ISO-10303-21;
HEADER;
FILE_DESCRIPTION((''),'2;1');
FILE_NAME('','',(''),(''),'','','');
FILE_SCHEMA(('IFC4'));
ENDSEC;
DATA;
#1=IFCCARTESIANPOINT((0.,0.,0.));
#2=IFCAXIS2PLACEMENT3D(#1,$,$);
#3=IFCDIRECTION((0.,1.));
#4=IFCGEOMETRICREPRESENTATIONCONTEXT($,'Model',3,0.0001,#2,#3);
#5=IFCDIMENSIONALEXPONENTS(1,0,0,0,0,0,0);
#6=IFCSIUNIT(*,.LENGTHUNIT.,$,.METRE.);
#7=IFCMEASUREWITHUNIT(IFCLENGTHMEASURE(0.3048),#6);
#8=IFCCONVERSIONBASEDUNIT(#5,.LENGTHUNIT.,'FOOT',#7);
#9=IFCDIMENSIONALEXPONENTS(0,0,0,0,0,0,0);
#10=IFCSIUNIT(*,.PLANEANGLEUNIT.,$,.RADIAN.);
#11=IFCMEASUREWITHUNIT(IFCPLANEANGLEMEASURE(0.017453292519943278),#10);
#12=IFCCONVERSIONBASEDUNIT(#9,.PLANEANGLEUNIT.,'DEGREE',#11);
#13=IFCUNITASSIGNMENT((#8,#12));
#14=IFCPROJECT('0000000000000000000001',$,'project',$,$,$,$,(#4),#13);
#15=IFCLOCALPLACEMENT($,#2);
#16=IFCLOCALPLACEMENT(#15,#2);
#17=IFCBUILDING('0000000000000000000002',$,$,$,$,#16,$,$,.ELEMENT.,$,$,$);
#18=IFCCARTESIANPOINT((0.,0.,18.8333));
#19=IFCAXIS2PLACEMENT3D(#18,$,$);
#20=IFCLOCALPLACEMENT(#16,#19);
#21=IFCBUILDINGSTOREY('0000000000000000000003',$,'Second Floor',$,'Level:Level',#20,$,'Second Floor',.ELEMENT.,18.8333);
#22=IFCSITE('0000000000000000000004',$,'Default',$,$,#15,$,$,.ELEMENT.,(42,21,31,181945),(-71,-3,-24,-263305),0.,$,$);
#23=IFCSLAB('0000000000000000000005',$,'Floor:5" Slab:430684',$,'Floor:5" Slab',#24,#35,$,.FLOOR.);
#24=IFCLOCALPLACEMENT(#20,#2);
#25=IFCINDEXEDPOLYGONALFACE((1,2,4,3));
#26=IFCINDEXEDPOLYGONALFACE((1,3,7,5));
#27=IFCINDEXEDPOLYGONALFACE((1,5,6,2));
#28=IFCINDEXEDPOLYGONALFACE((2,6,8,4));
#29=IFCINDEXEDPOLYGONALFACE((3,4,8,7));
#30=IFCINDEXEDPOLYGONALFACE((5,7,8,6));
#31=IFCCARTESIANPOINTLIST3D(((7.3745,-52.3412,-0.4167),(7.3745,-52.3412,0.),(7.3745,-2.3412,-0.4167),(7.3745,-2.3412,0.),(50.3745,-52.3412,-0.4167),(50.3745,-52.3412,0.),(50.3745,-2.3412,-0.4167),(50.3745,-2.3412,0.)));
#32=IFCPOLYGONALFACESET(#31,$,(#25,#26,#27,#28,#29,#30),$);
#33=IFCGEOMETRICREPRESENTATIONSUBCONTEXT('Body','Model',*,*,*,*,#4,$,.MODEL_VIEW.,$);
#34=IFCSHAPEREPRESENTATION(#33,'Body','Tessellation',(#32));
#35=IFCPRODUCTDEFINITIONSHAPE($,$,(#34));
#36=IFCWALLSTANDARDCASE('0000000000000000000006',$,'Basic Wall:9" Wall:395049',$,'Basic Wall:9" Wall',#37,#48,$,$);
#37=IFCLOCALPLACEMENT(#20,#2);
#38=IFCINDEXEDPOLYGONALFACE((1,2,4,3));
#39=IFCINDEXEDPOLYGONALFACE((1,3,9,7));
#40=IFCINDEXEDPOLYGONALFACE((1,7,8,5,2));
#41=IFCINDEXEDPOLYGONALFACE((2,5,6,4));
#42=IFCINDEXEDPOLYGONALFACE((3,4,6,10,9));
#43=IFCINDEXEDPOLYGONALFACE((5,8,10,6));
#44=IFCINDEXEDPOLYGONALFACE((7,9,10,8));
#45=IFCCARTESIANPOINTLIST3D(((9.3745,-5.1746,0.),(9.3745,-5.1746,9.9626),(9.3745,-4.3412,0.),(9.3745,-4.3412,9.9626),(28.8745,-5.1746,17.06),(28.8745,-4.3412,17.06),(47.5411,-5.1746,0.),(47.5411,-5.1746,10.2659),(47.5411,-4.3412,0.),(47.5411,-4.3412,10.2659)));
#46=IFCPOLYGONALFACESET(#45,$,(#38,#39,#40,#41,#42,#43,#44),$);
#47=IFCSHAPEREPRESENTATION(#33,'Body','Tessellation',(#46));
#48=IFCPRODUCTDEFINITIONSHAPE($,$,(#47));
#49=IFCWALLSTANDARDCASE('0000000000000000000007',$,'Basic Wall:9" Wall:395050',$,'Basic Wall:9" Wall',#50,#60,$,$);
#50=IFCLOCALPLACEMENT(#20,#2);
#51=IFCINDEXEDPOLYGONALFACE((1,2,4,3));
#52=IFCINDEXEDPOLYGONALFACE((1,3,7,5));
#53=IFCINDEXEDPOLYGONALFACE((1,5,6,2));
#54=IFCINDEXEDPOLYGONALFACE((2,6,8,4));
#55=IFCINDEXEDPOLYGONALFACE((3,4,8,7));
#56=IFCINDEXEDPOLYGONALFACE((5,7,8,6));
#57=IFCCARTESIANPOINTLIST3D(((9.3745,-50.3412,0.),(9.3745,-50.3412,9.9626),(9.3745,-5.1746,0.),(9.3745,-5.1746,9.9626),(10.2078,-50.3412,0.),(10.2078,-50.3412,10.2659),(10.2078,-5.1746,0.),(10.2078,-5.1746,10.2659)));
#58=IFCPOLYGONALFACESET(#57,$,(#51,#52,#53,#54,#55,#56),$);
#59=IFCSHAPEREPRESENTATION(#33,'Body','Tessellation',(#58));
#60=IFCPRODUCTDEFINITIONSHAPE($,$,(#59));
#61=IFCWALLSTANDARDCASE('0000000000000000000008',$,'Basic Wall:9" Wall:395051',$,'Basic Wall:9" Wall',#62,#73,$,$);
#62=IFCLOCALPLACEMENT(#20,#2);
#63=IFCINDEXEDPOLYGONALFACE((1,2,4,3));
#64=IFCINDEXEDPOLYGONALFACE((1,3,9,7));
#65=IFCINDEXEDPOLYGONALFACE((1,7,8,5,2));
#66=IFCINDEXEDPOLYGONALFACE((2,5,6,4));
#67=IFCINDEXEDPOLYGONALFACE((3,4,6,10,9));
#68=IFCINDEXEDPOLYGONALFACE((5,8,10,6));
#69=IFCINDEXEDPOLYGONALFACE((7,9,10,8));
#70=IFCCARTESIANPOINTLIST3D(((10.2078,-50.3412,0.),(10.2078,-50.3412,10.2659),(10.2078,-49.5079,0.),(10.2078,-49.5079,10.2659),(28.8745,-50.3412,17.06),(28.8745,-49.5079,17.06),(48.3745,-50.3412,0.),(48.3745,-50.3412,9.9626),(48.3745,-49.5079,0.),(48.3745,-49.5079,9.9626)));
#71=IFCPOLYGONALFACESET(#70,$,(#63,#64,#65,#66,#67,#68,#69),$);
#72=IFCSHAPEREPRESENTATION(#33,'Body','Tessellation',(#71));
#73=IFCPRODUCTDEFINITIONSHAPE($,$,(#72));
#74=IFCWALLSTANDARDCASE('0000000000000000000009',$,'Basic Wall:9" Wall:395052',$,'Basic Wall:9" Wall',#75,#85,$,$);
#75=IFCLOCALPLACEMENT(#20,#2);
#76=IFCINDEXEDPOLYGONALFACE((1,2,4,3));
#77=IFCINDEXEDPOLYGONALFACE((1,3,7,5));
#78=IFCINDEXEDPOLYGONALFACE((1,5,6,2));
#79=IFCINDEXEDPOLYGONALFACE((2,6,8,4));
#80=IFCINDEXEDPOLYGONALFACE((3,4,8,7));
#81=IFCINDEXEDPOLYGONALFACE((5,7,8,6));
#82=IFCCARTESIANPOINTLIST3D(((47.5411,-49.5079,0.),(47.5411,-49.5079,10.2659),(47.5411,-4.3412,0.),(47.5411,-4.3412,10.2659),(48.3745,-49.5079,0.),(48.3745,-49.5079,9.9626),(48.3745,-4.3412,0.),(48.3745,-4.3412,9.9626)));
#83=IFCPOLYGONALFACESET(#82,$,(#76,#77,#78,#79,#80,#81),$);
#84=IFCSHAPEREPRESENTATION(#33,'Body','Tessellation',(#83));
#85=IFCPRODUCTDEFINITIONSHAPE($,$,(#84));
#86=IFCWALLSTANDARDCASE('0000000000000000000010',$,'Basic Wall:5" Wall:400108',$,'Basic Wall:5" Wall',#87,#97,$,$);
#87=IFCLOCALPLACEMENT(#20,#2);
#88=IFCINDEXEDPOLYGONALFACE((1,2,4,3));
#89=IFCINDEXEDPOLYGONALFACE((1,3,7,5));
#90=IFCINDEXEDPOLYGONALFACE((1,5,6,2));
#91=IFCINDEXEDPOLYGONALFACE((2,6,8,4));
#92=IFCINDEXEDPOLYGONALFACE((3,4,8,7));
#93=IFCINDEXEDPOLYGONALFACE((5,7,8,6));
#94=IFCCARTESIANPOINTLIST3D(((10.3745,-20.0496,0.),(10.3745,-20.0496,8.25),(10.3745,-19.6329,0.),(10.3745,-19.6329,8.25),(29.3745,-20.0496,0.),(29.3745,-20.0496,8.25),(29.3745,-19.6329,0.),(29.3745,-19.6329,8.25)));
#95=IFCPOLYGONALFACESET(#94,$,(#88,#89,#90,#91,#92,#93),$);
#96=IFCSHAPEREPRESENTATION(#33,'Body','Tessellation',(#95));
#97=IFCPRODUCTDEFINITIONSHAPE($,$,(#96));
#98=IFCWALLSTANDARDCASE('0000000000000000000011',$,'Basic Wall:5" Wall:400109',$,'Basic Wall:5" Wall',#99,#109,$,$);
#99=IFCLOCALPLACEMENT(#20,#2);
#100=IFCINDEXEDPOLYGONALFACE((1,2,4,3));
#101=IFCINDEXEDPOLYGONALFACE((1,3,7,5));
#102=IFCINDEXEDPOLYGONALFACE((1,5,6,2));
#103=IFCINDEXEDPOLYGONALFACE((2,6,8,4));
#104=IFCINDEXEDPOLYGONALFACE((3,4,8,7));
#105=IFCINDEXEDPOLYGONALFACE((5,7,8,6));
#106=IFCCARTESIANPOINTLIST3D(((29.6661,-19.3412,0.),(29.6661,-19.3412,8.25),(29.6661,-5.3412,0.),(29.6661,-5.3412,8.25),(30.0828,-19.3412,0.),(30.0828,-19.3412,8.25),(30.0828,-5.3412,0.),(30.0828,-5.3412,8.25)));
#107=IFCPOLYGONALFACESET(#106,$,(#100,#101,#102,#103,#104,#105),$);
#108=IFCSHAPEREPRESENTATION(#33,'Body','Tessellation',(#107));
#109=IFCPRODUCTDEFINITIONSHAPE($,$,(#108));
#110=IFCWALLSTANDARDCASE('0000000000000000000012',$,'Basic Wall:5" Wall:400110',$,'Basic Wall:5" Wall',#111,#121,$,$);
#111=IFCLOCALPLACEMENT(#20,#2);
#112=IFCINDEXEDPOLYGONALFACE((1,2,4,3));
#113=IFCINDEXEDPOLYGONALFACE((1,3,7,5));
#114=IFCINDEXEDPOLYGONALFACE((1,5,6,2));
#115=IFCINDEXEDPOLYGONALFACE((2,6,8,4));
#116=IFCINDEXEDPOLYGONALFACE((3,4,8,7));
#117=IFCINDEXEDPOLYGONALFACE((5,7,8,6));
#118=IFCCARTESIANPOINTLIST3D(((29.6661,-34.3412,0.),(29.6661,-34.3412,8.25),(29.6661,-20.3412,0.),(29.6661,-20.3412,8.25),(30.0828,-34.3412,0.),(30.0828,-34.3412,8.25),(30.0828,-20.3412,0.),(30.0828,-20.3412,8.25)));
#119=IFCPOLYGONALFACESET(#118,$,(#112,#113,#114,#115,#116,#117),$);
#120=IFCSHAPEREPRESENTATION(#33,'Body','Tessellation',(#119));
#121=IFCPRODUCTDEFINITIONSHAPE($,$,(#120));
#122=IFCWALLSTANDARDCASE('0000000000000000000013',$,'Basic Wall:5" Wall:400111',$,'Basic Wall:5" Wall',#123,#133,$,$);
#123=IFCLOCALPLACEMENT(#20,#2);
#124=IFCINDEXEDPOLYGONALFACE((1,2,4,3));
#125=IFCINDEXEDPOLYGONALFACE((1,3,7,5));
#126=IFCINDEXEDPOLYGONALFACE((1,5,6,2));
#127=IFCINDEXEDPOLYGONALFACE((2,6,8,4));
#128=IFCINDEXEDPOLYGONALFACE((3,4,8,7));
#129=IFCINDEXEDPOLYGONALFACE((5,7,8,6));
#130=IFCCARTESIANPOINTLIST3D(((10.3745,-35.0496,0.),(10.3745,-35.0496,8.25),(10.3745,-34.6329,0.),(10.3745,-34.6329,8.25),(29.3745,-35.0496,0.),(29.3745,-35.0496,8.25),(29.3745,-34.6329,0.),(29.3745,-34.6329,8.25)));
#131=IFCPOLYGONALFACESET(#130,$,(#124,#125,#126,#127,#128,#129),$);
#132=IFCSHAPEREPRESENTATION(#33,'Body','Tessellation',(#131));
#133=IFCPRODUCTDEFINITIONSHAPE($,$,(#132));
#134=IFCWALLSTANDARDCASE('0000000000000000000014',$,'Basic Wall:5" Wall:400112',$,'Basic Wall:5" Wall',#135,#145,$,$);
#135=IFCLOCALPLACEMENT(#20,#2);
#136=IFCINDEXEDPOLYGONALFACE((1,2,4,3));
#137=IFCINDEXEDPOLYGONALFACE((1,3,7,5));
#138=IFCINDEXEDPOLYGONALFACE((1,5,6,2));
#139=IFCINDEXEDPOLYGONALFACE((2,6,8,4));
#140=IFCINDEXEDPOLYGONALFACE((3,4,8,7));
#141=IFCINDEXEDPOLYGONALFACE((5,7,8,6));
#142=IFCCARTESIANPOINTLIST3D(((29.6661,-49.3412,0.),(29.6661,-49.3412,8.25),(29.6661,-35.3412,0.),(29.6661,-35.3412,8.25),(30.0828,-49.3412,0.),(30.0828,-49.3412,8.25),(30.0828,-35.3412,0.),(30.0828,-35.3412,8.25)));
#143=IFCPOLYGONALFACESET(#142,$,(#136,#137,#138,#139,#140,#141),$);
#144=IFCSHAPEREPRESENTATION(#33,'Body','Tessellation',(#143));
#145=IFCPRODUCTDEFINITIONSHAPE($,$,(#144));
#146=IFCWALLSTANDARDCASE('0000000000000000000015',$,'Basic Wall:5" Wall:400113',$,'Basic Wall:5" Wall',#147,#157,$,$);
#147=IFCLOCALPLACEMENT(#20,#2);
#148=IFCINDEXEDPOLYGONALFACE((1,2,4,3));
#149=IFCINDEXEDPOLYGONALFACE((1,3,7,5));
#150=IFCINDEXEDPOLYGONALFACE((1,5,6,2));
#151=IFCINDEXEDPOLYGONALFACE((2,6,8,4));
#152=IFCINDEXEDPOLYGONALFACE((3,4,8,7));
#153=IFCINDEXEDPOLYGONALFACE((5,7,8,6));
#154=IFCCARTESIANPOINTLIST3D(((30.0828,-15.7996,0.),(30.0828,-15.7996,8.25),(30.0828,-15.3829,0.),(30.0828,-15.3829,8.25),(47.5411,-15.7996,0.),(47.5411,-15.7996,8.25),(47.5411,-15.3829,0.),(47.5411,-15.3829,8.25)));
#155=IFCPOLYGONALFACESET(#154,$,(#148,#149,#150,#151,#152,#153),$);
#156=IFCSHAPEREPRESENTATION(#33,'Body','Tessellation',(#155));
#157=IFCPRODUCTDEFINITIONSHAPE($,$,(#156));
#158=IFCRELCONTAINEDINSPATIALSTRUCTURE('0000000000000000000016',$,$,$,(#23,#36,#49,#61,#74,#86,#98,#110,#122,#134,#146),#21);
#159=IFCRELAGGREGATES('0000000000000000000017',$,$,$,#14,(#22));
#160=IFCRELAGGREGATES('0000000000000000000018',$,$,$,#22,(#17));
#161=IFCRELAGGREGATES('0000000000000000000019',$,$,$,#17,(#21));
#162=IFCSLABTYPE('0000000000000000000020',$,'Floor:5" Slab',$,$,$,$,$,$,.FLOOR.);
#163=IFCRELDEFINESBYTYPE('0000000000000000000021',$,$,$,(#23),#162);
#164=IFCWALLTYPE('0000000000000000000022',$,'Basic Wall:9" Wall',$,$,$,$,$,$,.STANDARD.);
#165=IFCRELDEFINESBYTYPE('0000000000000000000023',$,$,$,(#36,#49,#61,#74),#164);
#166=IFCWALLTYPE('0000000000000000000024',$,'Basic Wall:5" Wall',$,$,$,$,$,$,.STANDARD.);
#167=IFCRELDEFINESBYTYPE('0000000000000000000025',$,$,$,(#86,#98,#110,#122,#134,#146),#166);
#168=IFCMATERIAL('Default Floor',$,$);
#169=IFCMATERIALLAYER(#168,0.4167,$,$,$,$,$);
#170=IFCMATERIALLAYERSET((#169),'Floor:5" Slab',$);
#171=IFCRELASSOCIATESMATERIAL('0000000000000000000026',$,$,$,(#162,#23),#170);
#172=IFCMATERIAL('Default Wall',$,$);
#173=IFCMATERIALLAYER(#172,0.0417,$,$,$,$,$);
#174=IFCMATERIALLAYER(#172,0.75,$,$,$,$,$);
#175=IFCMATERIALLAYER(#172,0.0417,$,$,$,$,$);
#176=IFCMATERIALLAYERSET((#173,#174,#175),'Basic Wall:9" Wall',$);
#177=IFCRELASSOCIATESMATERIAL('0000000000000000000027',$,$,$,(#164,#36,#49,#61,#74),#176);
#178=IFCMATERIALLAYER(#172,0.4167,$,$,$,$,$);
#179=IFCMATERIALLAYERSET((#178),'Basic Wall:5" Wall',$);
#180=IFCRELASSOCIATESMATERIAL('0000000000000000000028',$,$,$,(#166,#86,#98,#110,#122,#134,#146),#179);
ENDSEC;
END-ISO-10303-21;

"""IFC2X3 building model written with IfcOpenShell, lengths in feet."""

from ifc_helpers import new_model, entity, si_unit, converted_unit, direction, frame, frame_2d, origin, origin_2d_with_axis, place, context, subcontext, project, spatial, polyline, rectangle, extrude, clip, bounded_halfspace, material, layer, layer_set, layer_usage, type_object, element, save


model = new_model("IFC2X3")

# Units and contexts
model_context = context("Model", 3, precision=0.0001, world=origin(), true_north=direction((0.0, 1.0)))
body_context = subcontext(model_context, "Body", "Model", "MODEL_VIEW")
ifc_project = project(units=[converted_unit("LENGTHUNIT", "FOOT", entity("IfcLengthMeasure", 0.3048), si_unit("LENGTHUNIT", "METRE"), dimensions=[1, 0, 0, 0, 0, 0, 0]), converted_unit("PLANEANGLEUNIT", "DEGREE", entity("IfcPlaneAngleMeasure", 0.017453292519943278), si_unit("PLANEANGLEUNIT", "RADIAN"), dimensions=[0, 0, 0, 0, 0, 0, 0])], contexts=[model_context])

# Site, building, storey
site_placement = place(None, origin())
site = spatial("IfcSite", under=ifc_project, at=site_placement, Name="Default", CompositionType="ELEMENT", RefLatitude=(42, 21, 31, 181945), RefLongitude=(-71, -3, -24, -263305), RefElevation=0.0)
building_placement = place(site_placement, origin())
building = spatial("IfcBuilding", under=site, at=building_placement, CompositionType="ELEMENT")
storey_placement = place(building_placement, frame((0.0, 0.0, 18.8333)))
storey = spatial("IfcBuildingStorey", under=building, at=storey_placement, Name="Second Floor", ObjectType="Level:Level", LongName="Second Floor", CompositionType="ELEMENT", Elevation=18.8333)

# Slab
ifc_material_1 = material(Name="Default Floor")
ifc_layer_1 = layer(ifc_material_1, 0.4167)
ifc_layer_set_1 = layer_set([ifc_layer_1], Name="Floor:5\" Slab")
ifc_layer_usage_1 = layer_usage(ifc_layer_set_1, "AXIS3", "POSITIVE", 0.0)
slab_type = type_object("IfcSlabType", Name="Floor:5\" Slab", PredefinedType="FLOOR", material=ifc_layer_set_1)
slab_placement = place(storey_placement, origin())
element("IfcSlab", 1, at=slab_placement, inside=storey, type_object=slab_type, material=ifc_layer_usage_1, Name="Floor:5\" Slab:430684", ObjectType="Floor:5\" Slab", PredefinedType="FLOOR", context=body_context, shape_type="SweptSolid", body=[
    extrude(rectangle(XDim=50.0, YDim=43.0, at=origin_2d_with_axis()), frame((28.8745, -27.3412, 0.0), z_axis=(0.0, 0.0, -1.0), x_axis=(0.0, 1.0, 0.0)), (0.0, 0.0, 1.0), 0.4167),
])

# Walls
ifc_material_2 = material(Name="Default Wall")
ifc_layer_2 = layer(ifc_material_2, 0.0417)
ifc_layer_3 = layer(ifc_material_2, 0.75)
ifc_layer_4 = layer(ifc_material_2, 0.0417)
ifc_layer_set_2 = layer_set([ifc_layer_2, ifc_layer_3, ifc_layer_4], Name="Basic Wall:9\" Wall")
ifc_layer_usage_2 = layer_usage(ifc_layer_set_2, "AXIS2", "NEGATIVE", 0.4167)
wall_type_1 = type_object("IfcWallType", Name="Basic Wall:9\" Wall", PredefinedType="STANDARD", material=ifc_layer_set_2)
wall_1_placement = place(storey_placement, frame((9.3745, -4.7579, 0.0)))
element("IfcWallStandardCase", 2, at=wall_1_placement, inside=storey, type_object=wall_type_1, material=ifc_layer_usage_2, Name="Basic Wall:9\" Wall:395049", ObjectType="Basic Wall:9\" Wall", context=body_context, shape_type="Clipping", body=[
    clip(clip(extrude(rectangle(XDim=38.1667, YDim=0.8333, at=frame_2d((19.0833, 0.0), x_axis=(-1.0, 0.0))), origin(), (0.0, 0.0, 1.0), 17.06), bounded_halfspace(frame((0.0, -0.4167, 9.9626), z_axis=(-0.34202, 0.0, 0.939693), x_axis=(0.0, -1.0, 0.0)), False, frame((0.0, -0.4167, 9.9626)), polyline([(0.0, 0.0), (0.8333, 0.0), (19.5, 0.0), (19.5, 0.8333), (0.0, 0.8333), (0.0, 0.0)]))), bounded_halfspace(frame((19.5, -0.4167, 17.06), z_axis=(0.34202, 0.0, 0.939693), x_axis=(0.0, 1.0, 0.0)), False, frame((19.5, -0.4167, 17.06)), polyline([(0.0, 0.0), (18.6667, 0.0), (18.6667, 0.8333), (0.0, 0.8333), (0.0, 0.0)]))),
])
wall_2_placement = place(storey_placement, frame((9.7911, -50.3412, 0.0), z_axis=(0.0, 0.0, 1.0), x_axis=(0.0, 1.0, 0.0)))
element("IfcWallStandardCase", 3, at=wall_2_placement, inside=storey, type_object=wall_type_1, material=ifc_layer_usage_2, Name="Basic Wall:9\" Wall:395050", ObjectType="Basic Wall:9\" Wall", context=body_context, shape_type="Clipping", body=[
    clip(extrude(rectangle(XDim=45.1667, YDim=0.8333, at=frame_2d((22.5833, 0.0), x_axis=(-1.0, 0.0))), origin(), (0.0, 0.0, 1.0), 10.2659), bounded_halfspace(frame((0.0, -0.4167, 10.2659), z_axis=(0.0, 0.34202, 0.939693), x_axis=(-1.0, 0.0, 0.0)), False, frame((0.0, -0.4167, 10.2659)), polyline([(0.0, 0.0), (0.8333, 0.0), (45.1667, 0.0), (45.1667, 0.8333), (0.0, 0.8333), (0.0, 0.0)]))),
])
wall_3_placement = place(storey_placement, frame((48.3745, -49.9246, 0.0), z_axis=(0.0, 0.0, 1.0), x_axis=(-1.0, 0.0, 0.0)))
element("IfcWallStandardCase", 4, at=wall_3_placement, inside=storey, type_object=wall_type_1, material=ifc_layer_usage_2, Name="Basic Wall:9\" Wall:395051", ObjectType="Basic Wall:9\" Wall", context=body_context, shape_type="Clipping", body=[
    clip(clip(extrude(rectangle(XDim=38.1667, YDim=0.8333, at=frame_2d((19.0833, 0.0), x_axis=(-1.0, 0.0))), origin(), (0.0, 0.0, 1.0), 17.06), bounded_halfspace(frame((19.5, -0.4167, 17.06), z_axis=(0.34202, 0.0, 0.939693), x_axis=(0.0, 1.0, 0.0)), False, frame((19.5, -0.4167, 17.06)), polyline([(0.0, 0.0), (18.6667, 0.0), (18.6667, 0.8333), (0.0, 0.8333), (0.0, 0.0)]))), bounded_halfspace(frame((0.0, -0.4167, 9.9626), z_axis=(-0.34202, 0.0, 0.939693), x_axis=(0.0, -1.0, 0.0)), False, frame((0.0, -0.4167, 9.9626)), polyline([(0.0, 0.0), (0.8333, 0.0), (19.5, 0.0), (19.5, 0.8333), (0.0, 0.8333), (0.0, 0.0)]))),
])
wall_4_placement = place(storey_placement, frame((47.9578, -4.3412, 0.0), z_axis=(0.0, 0.0, 1.0), x_axis=(0.0, -1.0, 0.0)))
element("IfcWallStandardCase", 5, at=wall_4_placement, inside=storey, type_object=wall_type_1, material=ifc_layer_usage_2, Name="Basic Wall:9\" Wall:395052", ObjectType="Basic Wall:9\" Wall", context=body_context, shape_type="Clipping", body=[
    clip(extrude(rectangle(XDim=45.1667, YDim=0.8333, at=frame_2d((22.5833, 0.0), x_axis=(-1.0, 0.0))), origin(), (0.0, 0.0, 1.0), 10.2659), bounded_halfspace(frame((0.0, -0.4167, 10.2659), z_axis=(0.0, 0.34202, 0.939693), x_axis=(-1.0, 0.0, 0.0)), False, frame((0.0, -0.4167, 10.2659)), polyline([(0.0, 0.0), (0.8333, 0.0), (45.1667, 0.0), (45.1667, 0.8333), (0.0, 0.8333), (0.0, 0.0)]))),
])
ifc_layer_5 = layer(ifc_material_2, 0.4167)
ifc_layer_set_3 = layer_set([ifc_layer_5], Name="Basic Wall:5\" Wall")
ifc_layer_usage_3 = layer_usage(ifc_layer_set_3, "AXIS2", "NEGATIVE", 0.2083)
wall_type_2 = type_object("IfcWallType", Name="Basic Wall:5\" Wall", PredefinedType="STANDARD", material=ifc_layer_set_3)
wall_5_placement = place(storey_placement, frame((10.3745, -19.8412, 0.0)))
element("IfcWallStandardCase", 6, at=wall_5_placement, inside=storey, type_object=wall_type_2, material=ifc_layer_usage_3, Name="Basic Wall:5\" Wall:400108", ObjectType="Basic Wall:5\" Wall", context=body_context, shape_type="SweptSolid", body=[
    extrude(rectangle(XDim=19.0, YDim=0.4167, at=frame_2d((9.5, 0.0), x_axis=(-1.0, 0.0))), origin(), (0.0, 0.0, 1.0), 8.25),
])
wall_6_placement = place(storey_placement, frame((29.8745, -19.3412, 0.0), z_axis=(0.0, 0.0, 1.0), x_axis=(0.0, 1.0, 0.0)))
element("IfcWallStandardCase", 7, at=wall_6_placement, inside=storey, type_object=wall_type_2, material=ifc_layer_usage_3, Name="Basic Wall:5\" Wall:400109", ObjectType="Basic Wall:5\" Wall", context=body_context, shape_type="SweptSolid", body=[
    extrude(rectangle(XDim=14.0, YDim=0.4167, at=frame_2d((7.0, 0.0), x_axis=(-1.0, 0.0))), origin(), (0.0, 0.0, 1.0), 8.25),
])
wall_7_placement = place(storey_placement, frame((29.8745, -20.3412, 0.0), z_axis=(0.0, 0.0, 1.0), x_axis=(0.0, -1.0, 0.0)))
element("IfcWallStandardCase", 8, at=wall_7_placement, inside=storey, type_object=wall_type_2, material=ifc_layer_usage_3, Name="Basic Wall:5\" Wall:400110", ObjectType="Basic Wall:5\" Wall", context=body_context, shape_type="SweptSolid", body=[
    extrude(rectangle(XDim=14.0, YDim=0.4167, at=frame_2d((7.0, 0.0), x_axis=(-1.0, 0.0))), origin(), (0.0, 0.0, 1.0), 8.25),
])
wall_8_placement = place(storey_placement, frame((29.3745, -34.8412, 0.0), z_axis=(0.0, 0.0, 1.0), x_axis=(-1.0, 0.0, 0.0)))
element("IfcWallStandardCase", 9, at=wall_8_placement, inside=storey, type_object=wall_type_2, material=ifc_layer_usage_3, Name="Basic Wall:5\" Wall:400111", ObjectType="Basic Wall:5\" Wall", context=body_context, shape_type="SweptSolid", body=[
    extrude(rectangle(XDim=19.0, YDim=0.4167, at=frame_2d((9.5, 0.0), x_axis=(-1.0, 0.0))), origin(), (0.0, 0.0, 1.0), 8.25),
])
wall_9_placement = place(storey_placement, frame((29.8745, -35.3412, 0.0), z_axis=(0.0, 0.0, 1.0), x_axis=(0.0, -1.0, 0.0)))
element("IfcWallStandardCase", 10, at=wall_9_placement, inside=storey, type_object=wall_type_2, material=ifc_layer_usage_3, Name="Basic Wall:5\" Wall:400112", ObjectType="Basic Wall:5\" Wall", context=body_context, shape_type="SweptSolid", body=[
    extrude(rectangle(XDim=14.0, YDim=0.4167, at=frame_2d((7.0, 0.0), x_axis=(-1.0, 0.0))), origin(), (0.0, 0.0, 1.0), 8.25),
])
wall_10_placement = place(storey_placement, frame((30.0828, -15.5912, 0.0)))
element("IfcWallStandardCase", 11, at=wall_10_placement, inside=storey, type_object=wall_type_2, material=ifc_layer_usage_3, Name="Basic Wall:5\" Wall:400113", ObjectType="Basic Wall:5\" Wall", context=body_context, shape_type="SweptSolid", body=[
    extrude(rectangle(XDim=17.4583, YDim=0.4167, at=frame_2d((8.7292, 0.0), x_axis=(-1.0, 0.0))), origin(), (0.0, 0.0, 1.0), 8.25),
])

save(model, "model.ifc")
